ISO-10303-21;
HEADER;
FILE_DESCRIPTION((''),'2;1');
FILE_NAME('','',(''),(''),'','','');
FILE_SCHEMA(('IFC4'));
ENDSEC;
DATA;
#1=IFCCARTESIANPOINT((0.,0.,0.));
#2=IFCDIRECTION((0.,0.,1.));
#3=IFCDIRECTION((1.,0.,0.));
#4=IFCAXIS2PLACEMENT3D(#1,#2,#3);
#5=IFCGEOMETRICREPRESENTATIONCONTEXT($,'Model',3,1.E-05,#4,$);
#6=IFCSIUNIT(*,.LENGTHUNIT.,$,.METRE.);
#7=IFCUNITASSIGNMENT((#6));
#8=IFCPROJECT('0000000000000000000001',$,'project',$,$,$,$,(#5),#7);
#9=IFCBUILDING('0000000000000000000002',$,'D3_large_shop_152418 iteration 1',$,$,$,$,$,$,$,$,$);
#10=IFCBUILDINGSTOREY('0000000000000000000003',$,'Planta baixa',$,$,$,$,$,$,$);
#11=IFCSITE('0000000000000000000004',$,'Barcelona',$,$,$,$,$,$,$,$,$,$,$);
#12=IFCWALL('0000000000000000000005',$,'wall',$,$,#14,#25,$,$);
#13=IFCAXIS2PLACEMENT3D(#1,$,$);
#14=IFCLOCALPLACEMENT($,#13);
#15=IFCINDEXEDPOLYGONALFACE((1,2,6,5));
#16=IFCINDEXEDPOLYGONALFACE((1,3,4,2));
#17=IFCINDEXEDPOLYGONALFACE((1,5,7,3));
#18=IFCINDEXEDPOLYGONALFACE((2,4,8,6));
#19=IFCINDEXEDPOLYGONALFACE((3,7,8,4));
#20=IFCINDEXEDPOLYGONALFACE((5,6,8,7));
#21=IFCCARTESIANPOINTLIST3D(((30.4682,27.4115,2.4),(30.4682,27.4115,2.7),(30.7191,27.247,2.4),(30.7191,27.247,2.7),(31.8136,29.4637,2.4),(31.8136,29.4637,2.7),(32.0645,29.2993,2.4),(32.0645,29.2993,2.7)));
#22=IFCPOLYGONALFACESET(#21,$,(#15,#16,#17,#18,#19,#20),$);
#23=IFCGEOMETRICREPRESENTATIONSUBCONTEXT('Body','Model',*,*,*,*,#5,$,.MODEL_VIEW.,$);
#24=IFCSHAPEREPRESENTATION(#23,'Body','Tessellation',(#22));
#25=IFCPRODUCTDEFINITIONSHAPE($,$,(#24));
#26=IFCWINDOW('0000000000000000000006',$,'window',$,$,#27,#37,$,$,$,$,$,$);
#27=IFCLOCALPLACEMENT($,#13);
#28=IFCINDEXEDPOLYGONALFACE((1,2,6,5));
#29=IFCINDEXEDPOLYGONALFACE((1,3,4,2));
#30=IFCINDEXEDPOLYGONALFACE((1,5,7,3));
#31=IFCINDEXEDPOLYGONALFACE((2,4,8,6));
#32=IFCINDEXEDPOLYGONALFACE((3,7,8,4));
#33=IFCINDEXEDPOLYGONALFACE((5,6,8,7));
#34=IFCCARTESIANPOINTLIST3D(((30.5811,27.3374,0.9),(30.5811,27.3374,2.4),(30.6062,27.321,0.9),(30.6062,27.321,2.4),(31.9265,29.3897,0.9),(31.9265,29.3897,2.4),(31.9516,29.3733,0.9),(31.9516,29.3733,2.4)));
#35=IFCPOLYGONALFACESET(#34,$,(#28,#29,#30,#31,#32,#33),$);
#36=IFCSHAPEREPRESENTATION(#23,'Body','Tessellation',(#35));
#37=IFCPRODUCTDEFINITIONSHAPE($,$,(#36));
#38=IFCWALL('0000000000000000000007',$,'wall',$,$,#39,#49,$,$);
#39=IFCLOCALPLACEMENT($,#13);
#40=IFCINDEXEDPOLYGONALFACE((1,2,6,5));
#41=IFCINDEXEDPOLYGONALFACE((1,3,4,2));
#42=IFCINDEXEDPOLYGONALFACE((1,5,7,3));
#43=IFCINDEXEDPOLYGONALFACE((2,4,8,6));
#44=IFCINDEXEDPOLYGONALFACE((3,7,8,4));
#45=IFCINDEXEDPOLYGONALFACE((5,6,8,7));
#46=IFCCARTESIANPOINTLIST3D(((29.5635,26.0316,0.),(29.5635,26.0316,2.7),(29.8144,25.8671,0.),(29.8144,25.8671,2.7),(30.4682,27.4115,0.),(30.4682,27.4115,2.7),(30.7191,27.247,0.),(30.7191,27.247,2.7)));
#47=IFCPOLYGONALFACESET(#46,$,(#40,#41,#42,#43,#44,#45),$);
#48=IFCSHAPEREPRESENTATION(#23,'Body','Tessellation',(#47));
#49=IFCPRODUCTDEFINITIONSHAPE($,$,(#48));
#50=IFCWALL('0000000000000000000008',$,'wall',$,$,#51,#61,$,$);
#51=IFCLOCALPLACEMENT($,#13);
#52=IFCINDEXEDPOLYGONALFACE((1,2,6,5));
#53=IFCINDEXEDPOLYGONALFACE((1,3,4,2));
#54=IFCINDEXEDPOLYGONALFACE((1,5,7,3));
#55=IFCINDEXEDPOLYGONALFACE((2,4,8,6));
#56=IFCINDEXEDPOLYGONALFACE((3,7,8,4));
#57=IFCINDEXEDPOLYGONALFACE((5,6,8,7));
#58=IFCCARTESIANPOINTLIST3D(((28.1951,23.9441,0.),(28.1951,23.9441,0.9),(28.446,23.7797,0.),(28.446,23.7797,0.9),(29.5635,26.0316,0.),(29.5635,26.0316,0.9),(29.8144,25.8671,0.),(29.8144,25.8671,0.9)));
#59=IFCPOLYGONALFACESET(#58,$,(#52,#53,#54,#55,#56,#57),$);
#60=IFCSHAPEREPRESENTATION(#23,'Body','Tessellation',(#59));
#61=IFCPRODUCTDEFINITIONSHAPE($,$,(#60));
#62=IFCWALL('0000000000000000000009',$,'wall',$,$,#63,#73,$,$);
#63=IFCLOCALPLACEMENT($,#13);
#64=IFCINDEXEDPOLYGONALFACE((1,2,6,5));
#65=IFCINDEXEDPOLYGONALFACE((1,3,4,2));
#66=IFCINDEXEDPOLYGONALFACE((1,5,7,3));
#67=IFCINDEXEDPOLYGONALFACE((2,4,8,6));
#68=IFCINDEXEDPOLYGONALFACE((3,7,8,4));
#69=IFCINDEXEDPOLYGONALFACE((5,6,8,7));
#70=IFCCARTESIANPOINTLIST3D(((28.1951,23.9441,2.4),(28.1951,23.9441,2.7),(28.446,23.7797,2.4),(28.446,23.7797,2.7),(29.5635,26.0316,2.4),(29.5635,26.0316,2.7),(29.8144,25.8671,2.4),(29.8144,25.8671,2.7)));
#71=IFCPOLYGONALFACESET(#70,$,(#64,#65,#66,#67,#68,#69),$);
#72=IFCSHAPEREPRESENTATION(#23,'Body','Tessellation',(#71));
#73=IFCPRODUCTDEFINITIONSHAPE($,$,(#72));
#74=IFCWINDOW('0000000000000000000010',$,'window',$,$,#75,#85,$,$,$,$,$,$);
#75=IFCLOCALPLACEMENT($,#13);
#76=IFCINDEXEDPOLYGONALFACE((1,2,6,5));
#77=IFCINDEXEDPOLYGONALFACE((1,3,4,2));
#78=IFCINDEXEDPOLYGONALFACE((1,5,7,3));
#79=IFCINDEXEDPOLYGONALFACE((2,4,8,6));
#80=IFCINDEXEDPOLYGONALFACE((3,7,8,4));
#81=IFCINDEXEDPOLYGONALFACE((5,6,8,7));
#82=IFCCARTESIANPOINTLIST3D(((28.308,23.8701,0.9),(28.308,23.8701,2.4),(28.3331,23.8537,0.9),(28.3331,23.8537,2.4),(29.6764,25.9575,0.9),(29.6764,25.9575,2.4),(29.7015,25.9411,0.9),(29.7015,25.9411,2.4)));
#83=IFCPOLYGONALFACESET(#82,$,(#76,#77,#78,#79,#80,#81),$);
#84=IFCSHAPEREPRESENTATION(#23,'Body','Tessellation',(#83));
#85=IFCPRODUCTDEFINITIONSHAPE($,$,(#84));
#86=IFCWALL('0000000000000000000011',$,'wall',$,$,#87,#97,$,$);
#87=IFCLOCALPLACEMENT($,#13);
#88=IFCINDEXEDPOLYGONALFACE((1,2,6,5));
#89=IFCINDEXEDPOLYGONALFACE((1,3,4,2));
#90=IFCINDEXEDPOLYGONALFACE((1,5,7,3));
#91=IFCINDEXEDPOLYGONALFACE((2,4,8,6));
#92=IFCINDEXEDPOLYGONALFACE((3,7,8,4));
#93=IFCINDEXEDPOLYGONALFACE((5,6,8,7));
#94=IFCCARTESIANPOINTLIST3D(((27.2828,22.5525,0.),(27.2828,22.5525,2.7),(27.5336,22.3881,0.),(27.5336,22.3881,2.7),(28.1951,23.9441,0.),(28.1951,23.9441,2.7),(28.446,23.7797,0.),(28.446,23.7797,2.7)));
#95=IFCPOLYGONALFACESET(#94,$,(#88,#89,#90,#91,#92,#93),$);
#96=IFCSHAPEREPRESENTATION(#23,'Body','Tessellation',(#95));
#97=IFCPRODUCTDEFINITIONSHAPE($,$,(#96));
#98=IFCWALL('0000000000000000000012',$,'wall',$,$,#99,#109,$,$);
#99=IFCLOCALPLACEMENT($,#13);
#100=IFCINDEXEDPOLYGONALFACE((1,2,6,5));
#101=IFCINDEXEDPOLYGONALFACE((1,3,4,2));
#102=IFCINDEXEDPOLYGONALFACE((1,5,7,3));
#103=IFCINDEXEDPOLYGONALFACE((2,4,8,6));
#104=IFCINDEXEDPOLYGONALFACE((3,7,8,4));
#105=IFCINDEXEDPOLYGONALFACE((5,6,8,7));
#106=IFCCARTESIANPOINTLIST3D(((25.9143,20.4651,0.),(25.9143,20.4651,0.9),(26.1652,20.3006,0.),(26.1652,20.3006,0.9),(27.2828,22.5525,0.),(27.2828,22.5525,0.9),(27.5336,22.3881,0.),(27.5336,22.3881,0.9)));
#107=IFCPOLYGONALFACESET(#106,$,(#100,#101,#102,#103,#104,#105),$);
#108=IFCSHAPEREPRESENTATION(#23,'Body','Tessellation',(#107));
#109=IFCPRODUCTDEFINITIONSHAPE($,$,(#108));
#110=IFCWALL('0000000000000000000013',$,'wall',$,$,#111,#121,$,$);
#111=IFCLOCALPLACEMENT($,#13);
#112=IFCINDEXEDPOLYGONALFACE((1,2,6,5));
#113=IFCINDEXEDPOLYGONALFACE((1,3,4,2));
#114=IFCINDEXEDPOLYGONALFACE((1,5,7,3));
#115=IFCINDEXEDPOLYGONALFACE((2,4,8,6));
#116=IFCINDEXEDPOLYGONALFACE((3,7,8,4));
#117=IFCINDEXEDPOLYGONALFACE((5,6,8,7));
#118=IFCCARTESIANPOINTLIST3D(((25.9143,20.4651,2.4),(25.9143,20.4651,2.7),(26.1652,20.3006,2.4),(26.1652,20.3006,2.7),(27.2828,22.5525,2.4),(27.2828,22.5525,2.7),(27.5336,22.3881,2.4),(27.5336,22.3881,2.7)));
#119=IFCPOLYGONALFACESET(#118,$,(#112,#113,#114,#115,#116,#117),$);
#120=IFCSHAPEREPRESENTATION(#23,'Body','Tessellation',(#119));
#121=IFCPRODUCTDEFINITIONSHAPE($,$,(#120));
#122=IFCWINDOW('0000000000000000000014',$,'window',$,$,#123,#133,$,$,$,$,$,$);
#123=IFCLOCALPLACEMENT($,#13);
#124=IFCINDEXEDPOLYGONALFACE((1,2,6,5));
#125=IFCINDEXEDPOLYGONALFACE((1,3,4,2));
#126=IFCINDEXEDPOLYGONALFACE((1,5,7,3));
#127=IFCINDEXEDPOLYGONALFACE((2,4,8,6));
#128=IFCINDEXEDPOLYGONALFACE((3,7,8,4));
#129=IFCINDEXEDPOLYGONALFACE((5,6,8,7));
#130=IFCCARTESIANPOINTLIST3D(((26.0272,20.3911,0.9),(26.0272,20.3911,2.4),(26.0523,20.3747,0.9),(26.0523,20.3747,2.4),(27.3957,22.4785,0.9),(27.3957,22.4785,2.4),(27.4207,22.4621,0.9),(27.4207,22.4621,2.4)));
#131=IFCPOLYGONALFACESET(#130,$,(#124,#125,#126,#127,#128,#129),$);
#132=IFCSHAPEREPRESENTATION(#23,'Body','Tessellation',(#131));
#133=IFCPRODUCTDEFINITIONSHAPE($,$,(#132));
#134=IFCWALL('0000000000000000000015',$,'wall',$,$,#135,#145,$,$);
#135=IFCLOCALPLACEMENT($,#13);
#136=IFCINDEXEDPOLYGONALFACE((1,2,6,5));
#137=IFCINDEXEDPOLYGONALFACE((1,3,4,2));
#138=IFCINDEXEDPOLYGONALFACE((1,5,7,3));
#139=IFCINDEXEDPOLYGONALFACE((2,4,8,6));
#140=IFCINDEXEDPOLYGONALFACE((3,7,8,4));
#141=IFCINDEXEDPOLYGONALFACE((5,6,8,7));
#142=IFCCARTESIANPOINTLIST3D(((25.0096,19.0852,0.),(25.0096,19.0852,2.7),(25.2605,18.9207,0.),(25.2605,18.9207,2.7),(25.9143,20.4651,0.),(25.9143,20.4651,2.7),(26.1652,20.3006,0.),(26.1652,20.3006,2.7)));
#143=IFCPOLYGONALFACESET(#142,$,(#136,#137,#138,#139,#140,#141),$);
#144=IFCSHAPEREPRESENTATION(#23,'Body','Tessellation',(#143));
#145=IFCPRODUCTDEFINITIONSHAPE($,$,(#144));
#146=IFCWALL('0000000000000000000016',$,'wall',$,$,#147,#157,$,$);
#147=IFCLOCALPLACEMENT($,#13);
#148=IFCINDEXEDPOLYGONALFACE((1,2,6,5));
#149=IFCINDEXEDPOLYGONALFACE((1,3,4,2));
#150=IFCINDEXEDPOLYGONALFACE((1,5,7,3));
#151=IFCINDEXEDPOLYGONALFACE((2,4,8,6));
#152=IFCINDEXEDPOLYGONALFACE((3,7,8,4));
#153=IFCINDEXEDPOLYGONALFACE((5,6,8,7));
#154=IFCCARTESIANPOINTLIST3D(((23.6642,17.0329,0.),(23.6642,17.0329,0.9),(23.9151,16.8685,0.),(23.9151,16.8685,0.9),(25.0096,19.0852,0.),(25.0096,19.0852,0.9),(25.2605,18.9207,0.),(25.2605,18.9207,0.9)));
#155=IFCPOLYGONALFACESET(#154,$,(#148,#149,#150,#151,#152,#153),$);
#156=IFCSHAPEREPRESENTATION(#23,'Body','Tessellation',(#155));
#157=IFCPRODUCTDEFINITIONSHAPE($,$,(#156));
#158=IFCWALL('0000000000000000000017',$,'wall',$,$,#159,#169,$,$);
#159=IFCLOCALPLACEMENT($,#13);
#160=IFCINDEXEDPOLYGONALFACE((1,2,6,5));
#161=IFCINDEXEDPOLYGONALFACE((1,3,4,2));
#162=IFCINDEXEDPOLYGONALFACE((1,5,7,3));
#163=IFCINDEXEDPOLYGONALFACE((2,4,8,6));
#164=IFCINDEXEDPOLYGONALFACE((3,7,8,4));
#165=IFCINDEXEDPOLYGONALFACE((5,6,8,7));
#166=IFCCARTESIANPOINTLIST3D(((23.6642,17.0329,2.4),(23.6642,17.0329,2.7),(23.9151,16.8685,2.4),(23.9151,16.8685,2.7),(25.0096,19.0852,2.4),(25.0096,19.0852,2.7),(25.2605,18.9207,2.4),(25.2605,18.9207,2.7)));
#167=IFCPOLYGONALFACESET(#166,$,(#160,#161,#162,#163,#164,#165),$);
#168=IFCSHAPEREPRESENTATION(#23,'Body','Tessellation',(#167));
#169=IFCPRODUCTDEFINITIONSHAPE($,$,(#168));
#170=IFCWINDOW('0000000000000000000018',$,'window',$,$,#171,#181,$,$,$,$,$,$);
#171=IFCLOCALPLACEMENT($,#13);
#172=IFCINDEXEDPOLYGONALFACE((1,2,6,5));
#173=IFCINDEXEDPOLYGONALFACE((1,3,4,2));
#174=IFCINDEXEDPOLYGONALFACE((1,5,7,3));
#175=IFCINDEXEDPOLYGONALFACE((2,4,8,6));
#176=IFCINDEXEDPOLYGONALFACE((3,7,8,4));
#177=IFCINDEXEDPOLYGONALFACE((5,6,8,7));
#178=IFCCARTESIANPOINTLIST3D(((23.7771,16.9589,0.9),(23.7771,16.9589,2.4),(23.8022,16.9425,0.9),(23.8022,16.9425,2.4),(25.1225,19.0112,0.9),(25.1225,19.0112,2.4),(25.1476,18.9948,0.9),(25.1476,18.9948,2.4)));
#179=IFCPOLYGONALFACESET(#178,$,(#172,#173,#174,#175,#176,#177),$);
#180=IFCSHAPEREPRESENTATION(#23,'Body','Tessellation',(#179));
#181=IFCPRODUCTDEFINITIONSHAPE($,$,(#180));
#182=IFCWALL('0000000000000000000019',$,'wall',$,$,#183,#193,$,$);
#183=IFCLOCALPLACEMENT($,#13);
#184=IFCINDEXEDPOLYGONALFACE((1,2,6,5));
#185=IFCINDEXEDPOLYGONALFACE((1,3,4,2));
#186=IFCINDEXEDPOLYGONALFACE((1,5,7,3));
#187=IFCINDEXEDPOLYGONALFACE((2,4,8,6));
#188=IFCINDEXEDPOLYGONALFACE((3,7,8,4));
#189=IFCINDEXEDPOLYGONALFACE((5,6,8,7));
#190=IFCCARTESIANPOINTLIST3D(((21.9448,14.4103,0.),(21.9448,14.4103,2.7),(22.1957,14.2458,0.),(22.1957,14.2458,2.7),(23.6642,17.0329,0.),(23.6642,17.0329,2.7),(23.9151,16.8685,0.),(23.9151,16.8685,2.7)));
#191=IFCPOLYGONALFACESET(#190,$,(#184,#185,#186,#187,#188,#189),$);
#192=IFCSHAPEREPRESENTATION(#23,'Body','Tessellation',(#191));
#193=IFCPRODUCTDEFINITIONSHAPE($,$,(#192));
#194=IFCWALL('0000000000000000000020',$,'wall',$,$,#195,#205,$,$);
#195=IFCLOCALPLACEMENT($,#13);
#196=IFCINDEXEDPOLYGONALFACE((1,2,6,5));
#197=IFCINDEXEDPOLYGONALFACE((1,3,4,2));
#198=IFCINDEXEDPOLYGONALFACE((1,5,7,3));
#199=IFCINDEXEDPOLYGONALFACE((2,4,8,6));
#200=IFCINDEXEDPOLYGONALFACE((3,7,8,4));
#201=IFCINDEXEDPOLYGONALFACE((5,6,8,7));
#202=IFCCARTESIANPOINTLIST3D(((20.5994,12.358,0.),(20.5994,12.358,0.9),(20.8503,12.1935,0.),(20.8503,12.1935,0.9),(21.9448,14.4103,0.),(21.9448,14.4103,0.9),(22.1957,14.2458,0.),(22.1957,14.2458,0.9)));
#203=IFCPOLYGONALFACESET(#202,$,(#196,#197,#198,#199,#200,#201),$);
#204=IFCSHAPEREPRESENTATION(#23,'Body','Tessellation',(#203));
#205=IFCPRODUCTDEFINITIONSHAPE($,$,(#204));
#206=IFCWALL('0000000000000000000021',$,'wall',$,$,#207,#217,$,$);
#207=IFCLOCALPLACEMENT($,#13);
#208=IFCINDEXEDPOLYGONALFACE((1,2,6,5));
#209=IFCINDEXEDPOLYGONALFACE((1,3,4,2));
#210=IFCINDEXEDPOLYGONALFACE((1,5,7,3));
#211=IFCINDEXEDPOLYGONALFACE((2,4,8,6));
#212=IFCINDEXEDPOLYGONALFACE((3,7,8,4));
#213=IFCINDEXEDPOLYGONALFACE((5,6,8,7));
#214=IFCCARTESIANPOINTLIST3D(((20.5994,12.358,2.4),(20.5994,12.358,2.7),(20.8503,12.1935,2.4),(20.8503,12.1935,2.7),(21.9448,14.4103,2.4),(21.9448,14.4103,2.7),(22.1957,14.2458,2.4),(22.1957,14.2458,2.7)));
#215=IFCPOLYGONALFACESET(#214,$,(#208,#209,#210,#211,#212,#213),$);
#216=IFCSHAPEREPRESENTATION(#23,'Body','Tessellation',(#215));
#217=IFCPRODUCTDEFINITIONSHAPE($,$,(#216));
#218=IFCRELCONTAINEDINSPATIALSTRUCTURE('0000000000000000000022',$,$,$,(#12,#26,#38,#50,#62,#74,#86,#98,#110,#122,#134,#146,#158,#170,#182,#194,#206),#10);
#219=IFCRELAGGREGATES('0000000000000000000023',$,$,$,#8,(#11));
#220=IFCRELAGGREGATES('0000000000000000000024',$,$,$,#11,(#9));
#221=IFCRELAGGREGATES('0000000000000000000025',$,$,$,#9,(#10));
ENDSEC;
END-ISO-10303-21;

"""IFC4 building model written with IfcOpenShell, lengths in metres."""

from ifc_helpers import new_model, si_unit, frame, origin, origin_with_axes, place, context, subcontext, project, spatial, polyline, outline, extrude, element, save


model = new_model("IFC4")

# Units and contexts
model_context = context("Model", 3, precision=1e-05, world=origin_with_axes())
body_context = subcontext(model_context, "Body", "Model", "MODEL_VIEW")
ifc_project = project(units=[si_unit("LENGTHUNIT", "METRE")], contexts=[model_context])

# Site, building, storey
site = spatial("IfcSite", under=ifc_project, Name="Barcelona")
building = spatial("IfcBuilding", under=site, Name="D3_large_shop_152418 iteration 1")
storey = spatial("IfcBuildingStorey", under=building, Name="Planta baixa")

# Wall
wall_1_placement = place(None, origin_with_axes())
element("IfcWall", 1, at=wall_1_placement, inside=storey, Name="wall", context=body_context, shape_type="SweptSolid", body=[
    extrude(outline(polyline([(32.0645, 29.2993), (30.7191, 27.247), (30.4682, 27.4115), (31.8136, 29.4637), (32.0645, 29.2993)])), frame((0.0, 0.0, 2.4)), (0.0, 0.0, 1.0), 0.3),
])

# Window
window_1_placement = place(None, origin_with_axes())
element("IfcWindow", 2, at=window_1_placement, inside=storey, Name="window", context=body_context, shape_type="SweptSolid", body=[
    extrude(outline(polyline([(31.9516, 29.3733), (30.6062, 27.321), (30.5811, 27.3374), (31.9265, 29.3897), (31.9516, 29.3733)])), frame((0.0, 0.0, 0.9)), (0.0, 0.0, 1.0), 1.5),
])

# Walls
wall_2_placement = place(None, origin_with_axes())
element("IfcWall", 3, at=wall_2_placement, inside=storey, Name="wall", context=body_context, shape_type="SweptSolid", body=[
    extrude(outline(polyline([(30.7191, 27.247), (29.8144, 25.8671), (29.5635, 26.0316), (30.4682, 27.4115), (30.7191, 27.247)])), origin(), (0.0, 0.0, 1.0), 2.7),
])
wall_3_placement = place(None, origin_with_axes())
element("IfcWall", 4, at=wall_3_placement, inside=storey, Name="wall", context=body_context, shape_type="SweptSolid", body=[
    extrude(outline(polyline([(29.8144, 25.8671), (28.446, 23.7797), (28.1951, 23.9441), (29.5635, 26.0316), (29.8144, 25.8671)])), origin(), (0.0, 0.0, 1.0), 0.9),
])
wall_4_placement = place(None, origin_with_axes())
element("IfcWall", 5, at=wall_4_placement, inside=storey, Name="wall", context=body_context, shape_type="SweptSolid", body=[
    extrude(outline(polyline([(29.8144, 25.8671), (28.446, 23.7797), (28.1951, 23.9441), (29.5635, 26.0316), (29.8144, 25.8671)])), frame((0.0, 0.0, 2.4)), (0.0, 0.0, 1.0), 0.3),
])

# Window
window_2_placement = place(None, origin_with_axes())
element("IfcWindow", 6, at=window_2_placement, inside=storey, Name="window", context=body_context, shape_type="SweptSolid", body=[
    extrude(outline(polyline([(29.7015, 25.9411), (28.3331, 23.8537), (28.308, 23.8701), (29.6764, 25.9575), (29.7015, 25.9411)])), frame((0.0, 0.0, 0.9)), (0.0, 0.0, 1.0), 1.5),
])

# Walls
wall_5_placement = place(None, origin_with_axes())
element("IfcWall", 7, at=wall_5_placement, inside=storey, Name="wall", context=body_context, shape_type="SweptSolid", body=[
    extrude(outline(polyline([(28.446, 23.7797), (27.5336, 22.3881), (27.2828, 22.5525), (28.1951, 23.9441), (28.446, 23.7797)])), origin(), (0.0, 0.0, 1.0), 2.7),
])
wall_6_placement = place(None, origin_with_axes())
element("IfcWall", 8, at=wall_6_placement, inside=storey, Name="wall", context=body_context, shape_type="SweptSolid", body=[
    extrude(outline(polyline([(27.5336, 22.3881), (26.1652, 20.3006), (25.9143, 20.4651), (27.2828, 22.5525), (27.5336, 22.3881)])), origin(), (0.0, 0.0, 1.0), 0.9),
])
wall_7_placement = place(None, origin_with_axes())
element("IfcWall", 9, at=wall_7_placement, inside=storey, Name="wall", context=body_context, shape_type="SweptSolid", body=[
    extrude(outline(polyline([(27.5336, 22.3881), (26.1652, 20.3006), (25.9143, 20.4651), (27.2828, 22.5525), (27.5336, 22.3881)])), frame((0.0, 0.0, 2.4)), (0.0, 0.0, 1.0), 0.3),
])

# Window
window_3_placement = place(None, origin_with_axes())
element("IfcWindow", 10, at=window_3_placement, inside=storey, Name="window", context=body_context, shape_type="SweptSolid", body=[
    extrude(outline(polyline([(27.4207, 22.4621), (26.0523, 20.3747), (26.0272, 20.3911), (27.3957, 22.4785), (27.4207, 22.4621)])), frame((0.0, 0.0, 0.9)), (0.0, 0.0, 1.0), 1.5),
])

# Walls
wall_8_placement = place(None, origin_with_axes())
element("IfcWall", 11, at=wall_8_placement, inside=storey, Name="wall", context=body_context, shape_type="SweptSolid", body=[
    extrude(outline(polyline([(26.1652, 20.3006), (25.2605, 18.9207), (25.0096, 19.0852), (25.9143, 20.4651), (26.1652, 20.3006)])), origin(), (0.0, 0.0, 1.0), 2.7),
])
wall_9_placement = place(None, origin_with_axes())
element("IfcWall", 12, at=wall_9_placement, inside=storey, Name="wall", context=body_context, shape_type="SweptSolid", body=[
    extrude(outline(polyline([(25.2605, 18.9207), (23.9151, 16.8685), (23.6642, 17.0329), (25.0096, 19.0852), (25.2605, 18.9207)])), origin(), (0.0, 0.0, 1.0), 0.9),
])
wall_10_placement = place(None, origin_with_axes())
element("IfcWall", 13, at=wall_10_placement, inside=storey, Name="wall", context=body_context, shape_type="SweptSolid", body=[
    extrude(outline(polyline([(25.2605, 18.9207), (23.9151, 16.8685), (23.6642, 17.0329), (25.0096, 19.0852), (25.2605, 18.9207)])), frame((0.0, 0.0, 2.4)), (0.0, 0.0, 1.0), 0.3),
])

# Window
window_4_placement = place(None, origin_with_axes())
element("IfcWindow", 14, at=window_4_placement, inside=storey, Name="window", context=body_context, shape_type="SweptSolid", body=[
    extrude(outline(polyline([(25.1476, 18.9948), (23.8022, 16.9425), (23.7771, 16.9589), (25.1225, 19.0112), (25.1476, 18.9948)])), frame((0.0, 0.0, 0.9)), (0.0, 0.0, 1.0), 1.5),
])

# Walls
wall_11_placement = place(None, origin_with_axes())
element("IfcWall", 15, at=wall_11_placement, inside=storey, Name="wall", context=body_context, shape_type="SweptSolid", body=[
    extrude(outline(polyline([(23.9151, 16.8685), (22.1957, 14.2458), (21.9448, 14.4103), (23.6642, 17.0329), (23.9151, 16.8685)])), origin(), (0.0, 0.0, 1.0), 2.7),
])
wall_12_placement = place(None, origin_with_axes())
element("IfcWall", 16, at=wall_12_placement, inside=storey, Name="wall", context=body_context, shape_type="SweptSolid", body=[
    extrude(outline(polyline([(22.1957, 14.2458), (20.8503, 12.1935), (20.5994, 12.358), (21.9448, 14.4103), (22.1957, 14.2458)])), origin(), (0.0, 0.0, 1.0), 0.9),
])
wall_13_placement = place(None, origin_with_axes())
element("IfcWall", 17, at=wall_13_placement, inside=storey, Name="wall", context=body_context, shape_type="SweptSolid", body=[
    extrude(outline(polyline([(22.1957, 14.2458), (20.8503, 12.1935), (20.5994, 12.358), (21.9448, 14.4103), (22.1957, 14.2458)])), frame((0.0, 0.0, 2.4)), (0.0, 0.0, 1.0), 0.3),
])

save(model, "model.ifc")
